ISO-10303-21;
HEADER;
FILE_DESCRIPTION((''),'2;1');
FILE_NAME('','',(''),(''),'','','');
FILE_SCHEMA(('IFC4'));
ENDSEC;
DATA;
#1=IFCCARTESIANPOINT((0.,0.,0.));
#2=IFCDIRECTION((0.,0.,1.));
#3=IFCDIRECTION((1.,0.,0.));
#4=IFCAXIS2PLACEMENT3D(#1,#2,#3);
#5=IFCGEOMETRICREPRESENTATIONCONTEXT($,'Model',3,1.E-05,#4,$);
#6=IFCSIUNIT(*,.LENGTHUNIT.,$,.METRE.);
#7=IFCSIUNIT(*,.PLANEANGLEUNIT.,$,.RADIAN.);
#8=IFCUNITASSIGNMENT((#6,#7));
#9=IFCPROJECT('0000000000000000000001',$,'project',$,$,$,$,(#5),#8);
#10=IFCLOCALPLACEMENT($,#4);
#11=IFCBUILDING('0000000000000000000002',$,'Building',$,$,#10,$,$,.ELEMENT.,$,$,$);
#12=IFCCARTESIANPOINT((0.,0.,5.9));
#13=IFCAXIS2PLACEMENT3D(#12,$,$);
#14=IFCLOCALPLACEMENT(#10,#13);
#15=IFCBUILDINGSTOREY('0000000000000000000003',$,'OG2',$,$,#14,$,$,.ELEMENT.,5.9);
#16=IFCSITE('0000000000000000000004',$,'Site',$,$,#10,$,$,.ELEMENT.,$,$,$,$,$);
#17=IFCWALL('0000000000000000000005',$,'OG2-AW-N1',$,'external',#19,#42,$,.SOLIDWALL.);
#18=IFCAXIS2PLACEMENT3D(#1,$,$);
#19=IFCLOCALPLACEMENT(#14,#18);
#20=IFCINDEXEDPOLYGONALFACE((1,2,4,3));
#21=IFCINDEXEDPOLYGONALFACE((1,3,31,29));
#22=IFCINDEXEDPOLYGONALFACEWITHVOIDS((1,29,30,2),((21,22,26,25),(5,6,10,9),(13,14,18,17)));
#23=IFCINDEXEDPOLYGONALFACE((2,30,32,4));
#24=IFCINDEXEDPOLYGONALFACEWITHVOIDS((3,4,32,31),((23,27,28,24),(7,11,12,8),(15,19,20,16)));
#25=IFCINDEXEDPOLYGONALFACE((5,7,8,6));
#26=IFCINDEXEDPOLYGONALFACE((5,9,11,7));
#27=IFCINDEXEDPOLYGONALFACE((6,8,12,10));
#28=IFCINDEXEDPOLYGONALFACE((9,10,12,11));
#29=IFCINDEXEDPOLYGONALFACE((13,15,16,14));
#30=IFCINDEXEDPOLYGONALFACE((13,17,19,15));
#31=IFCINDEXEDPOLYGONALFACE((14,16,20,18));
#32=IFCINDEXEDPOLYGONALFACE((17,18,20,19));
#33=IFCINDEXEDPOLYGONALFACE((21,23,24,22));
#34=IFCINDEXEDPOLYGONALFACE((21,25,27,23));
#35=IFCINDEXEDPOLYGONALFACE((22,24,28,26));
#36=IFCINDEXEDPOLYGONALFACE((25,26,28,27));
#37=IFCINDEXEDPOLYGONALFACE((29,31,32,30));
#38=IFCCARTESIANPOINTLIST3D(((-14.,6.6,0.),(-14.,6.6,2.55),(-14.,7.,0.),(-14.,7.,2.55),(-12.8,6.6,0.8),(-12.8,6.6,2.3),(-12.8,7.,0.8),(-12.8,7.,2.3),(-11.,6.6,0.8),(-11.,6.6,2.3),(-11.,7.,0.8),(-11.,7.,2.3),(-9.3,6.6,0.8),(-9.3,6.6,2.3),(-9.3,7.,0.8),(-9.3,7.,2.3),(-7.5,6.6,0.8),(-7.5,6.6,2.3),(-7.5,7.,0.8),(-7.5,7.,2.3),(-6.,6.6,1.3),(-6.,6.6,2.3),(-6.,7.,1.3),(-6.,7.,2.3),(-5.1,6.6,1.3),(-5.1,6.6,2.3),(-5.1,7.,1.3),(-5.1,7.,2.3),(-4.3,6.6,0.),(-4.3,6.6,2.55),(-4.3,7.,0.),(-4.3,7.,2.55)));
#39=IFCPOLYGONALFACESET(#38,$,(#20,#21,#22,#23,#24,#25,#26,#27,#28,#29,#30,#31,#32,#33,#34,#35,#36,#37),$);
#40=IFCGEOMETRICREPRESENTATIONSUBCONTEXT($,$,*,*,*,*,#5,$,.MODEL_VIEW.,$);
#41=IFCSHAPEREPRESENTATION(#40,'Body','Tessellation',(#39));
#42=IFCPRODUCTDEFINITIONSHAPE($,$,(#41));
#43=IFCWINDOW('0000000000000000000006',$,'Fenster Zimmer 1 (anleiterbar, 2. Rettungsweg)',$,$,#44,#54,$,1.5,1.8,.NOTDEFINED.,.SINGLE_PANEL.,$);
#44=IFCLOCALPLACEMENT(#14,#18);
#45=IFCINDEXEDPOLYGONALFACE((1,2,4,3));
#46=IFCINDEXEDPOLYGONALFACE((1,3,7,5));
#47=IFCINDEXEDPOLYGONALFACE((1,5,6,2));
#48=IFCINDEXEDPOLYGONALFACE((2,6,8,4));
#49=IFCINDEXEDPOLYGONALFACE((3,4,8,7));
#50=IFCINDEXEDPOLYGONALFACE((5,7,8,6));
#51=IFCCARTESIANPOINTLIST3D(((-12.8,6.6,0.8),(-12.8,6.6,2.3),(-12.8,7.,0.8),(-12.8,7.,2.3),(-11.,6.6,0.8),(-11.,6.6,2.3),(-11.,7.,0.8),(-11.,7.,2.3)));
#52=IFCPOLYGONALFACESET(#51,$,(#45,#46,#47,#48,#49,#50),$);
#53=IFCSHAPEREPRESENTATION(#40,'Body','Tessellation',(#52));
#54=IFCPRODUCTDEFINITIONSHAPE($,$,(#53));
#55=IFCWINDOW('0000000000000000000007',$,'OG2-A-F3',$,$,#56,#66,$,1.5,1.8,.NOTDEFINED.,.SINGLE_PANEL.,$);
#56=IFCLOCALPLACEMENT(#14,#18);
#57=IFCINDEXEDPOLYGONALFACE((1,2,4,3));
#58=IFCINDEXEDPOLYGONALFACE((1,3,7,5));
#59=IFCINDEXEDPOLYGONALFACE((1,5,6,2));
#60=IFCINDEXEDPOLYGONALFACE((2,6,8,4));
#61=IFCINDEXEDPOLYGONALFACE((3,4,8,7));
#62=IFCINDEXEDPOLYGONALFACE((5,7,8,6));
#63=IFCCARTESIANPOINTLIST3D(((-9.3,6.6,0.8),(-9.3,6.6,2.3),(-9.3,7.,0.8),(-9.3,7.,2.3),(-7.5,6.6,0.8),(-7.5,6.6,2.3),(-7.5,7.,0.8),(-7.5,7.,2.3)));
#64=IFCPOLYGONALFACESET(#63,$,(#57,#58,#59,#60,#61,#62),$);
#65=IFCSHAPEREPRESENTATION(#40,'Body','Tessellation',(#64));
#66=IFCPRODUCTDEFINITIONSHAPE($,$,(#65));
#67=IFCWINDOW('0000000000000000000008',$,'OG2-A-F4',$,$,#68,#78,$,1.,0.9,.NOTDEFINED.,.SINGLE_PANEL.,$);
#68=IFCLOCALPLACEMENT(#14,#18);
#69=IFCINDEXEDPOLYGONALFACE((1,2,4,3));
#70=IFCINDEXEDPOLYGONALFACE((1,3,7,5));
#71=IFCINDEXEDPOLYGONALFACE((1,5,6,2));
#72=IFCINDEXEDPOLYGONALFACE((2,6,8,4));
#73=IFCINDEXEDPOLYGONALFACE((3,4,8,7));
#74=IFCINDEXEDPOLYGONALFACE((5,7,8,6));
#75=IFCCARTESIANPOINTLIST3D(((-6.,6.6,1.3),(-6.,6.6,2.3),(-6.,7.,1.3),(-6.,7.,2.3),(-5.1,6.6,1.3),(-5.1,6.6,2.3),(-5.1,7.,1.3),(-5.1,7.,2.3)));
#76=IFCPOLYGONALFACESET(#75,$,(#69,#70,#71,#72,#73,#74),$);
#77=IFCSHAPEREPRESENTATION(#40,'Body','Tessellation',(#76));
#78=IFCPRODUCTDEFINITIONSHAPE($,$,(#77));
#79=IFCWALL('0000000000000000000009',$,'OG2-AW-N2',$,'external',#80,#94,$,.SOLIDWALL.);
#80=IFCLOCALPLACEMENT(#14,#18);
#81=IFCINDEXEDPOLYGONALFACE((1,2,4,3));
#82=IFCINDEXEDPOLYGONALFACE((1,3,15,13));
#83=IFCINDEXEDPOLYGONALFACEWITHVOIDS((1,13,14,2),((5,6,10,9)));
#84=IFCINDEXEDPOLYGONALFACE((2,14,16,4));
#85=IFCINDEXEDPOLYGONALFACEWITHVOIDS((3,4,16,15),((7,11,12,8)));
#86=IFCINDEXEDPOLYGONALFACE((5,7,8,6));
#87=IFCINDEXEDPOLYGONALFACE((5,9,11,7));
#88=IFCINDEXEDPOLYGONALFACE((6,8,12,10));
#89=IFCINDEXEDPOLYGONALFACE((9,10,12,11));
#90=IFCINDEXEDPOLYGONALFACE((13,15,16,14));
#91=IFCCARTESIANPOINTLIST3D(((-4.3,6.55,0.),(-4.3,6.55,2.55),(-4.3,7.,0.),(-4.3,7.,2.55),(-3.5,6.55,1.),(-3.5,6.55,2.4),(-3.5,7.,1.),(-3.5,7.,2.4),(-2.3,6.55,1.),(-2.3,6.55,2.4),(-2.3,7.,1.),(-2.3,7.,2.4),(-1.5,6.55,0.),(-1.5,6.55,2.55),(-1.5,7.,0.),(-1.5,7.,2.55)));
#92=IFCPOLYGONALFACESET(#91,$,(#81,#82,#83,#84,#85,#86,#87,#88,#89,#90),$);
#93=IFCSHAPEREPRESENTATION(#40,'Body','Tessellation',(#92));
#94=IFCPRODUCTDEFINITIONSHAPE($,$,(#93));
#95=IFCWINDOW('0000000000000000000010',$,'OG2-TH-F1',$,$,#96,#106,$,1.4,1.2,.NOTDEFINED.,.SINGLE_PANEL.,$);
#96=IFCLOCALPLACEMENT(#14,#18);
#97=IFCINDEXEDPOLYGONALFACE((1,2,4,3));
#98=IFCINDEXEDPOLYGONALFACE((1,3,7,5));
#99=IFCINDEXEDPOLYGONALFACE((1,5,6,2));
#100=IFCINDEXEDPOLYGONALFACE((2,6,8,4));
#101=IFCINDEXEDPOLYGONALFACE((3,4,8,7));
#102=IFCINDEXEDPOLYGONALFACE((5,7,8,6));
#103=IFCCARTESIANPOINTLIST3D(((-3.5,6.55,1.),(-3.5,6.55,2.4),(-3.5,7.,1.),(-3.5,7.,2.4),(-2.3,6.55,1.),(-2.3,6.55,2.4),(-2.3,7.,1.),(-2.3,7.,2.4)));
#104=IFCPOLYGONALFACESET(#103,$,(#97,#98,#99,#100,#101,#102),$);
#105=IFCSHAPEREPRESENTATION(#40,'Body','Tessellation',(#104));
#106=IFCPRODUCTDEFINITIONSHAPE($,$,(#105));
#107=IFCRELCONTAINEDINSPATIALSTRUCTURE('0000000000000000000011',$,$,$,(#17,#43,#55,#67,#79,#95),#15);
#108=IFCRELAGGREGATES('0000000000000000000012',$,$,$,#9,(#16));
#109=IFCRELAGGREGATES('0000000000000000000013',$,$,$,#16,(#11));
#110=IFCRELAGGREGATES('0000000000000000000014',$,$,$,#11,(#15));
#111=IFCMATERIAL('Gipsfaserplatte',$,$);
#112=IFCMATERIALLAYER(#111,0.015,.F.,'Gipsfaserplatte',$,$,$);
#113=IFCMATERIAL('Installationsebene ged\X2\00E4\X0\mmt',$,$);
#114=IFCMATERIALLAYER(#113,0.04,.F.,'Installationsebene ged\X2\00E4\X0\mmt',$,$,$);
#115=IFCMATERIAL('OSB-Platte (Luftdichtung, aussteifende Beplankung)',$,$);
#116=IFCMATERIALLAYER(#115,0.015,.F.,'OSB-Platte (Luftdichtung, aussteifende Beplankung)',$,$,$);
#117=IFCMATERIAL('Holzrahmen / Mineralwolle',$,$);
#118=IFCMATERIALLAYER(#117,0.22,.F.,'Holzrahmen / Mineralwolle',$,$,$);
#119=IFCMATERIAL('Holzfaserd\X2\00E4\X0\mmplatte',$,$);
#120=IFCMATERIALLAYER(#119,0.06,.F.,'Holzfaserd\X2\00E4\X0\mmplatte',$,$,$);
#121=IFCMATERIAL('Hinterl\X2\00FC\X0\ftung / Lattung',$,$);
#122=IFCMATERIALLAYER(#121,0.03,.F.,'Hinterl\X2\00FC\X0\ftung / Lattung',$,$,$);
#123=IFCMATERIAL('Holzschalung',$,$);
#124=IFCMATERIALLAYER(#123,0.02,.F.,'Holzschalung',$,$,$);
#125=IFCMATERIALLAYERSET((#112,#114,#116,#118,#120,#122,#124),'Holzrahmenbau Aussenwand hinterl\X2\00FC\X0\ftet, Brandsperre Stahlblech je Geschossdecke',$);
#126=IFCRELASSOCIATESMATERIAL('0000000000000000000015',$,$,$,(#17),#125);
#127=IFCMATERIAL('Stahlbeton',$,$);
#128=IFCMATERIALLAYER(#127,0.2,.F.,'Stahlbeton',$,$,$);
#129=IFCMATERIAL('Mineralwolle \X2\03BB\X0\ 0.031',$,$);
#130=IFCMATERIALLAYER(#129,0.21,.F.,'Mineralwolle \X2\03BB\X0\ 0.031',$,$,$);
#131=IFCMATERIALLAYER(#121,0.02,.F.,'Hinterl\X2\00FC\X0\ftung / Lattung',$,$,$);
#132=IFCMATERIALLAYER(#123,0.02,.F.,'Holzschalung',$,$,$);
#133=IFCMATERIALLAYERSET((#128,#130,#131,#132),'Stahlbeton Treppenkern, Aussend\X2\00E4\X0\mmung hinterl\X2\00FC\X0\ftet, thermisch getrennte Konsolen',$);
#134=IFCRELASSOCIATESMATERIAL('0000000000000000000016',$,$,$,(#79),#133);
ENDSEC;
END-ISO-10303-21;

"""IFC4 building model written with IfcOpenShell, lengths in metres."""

from ifc_helpers import new_model, si_unit, frame, frame_2d, origin, origin_with_axes, place, context, subcontext, project, spatial, rectangle, extrude, material, layer, layer_set, element, fill, save


model = new_model("IFC4")

# Units and contexts
model_context = context("Model", 3, precision=1e-05, world=origin_with_axes())
sub_context = subcontext(model_context, None, None, "MODEL_VIEW")
ifc_project = project(units=[si_unit("LENGTHUNIT", "METRE"), si_unit("PLANEANGLEUNIT", "RADIAN")], contexts=[model_context])

# Site, building, storey
placement = place(None, origin_with_axes())
site = spatial("IfcSite", under=ifc_project, at=placement, Name="Site", CompositionType="ELEMENT")
building = spatial("IfcBuilding", under=site, at=placement, Name="Building", CompositionType="ELEMENT")
storey_placement = place(placement, frame((0.0, 0.0, 5.9)))
storey = spatial("IfcBuildingStorey", under=building, at=storey_placement, Name="OG2", CompositionType="ELEMENT", Elevation=5.9)

# Wall, openings, windows
ifc_material_1 = material(Name="Gipsfaserplatte")
ifc_layer_1 = layer(ifc_material_1, 0.015, ventilated=False, Name="Gipsfaserplatte")
ifc_material_2 = material(Name="Installationsebene gedämmt")
ifc_layer_2 = layer(ifc_material_2, 0.04, ventilated=False, Name="Installationsebene gedämmt")
ifc_material_3 = material(Name="OSB-Platte (Luftdichtung, aussteifende Beplankung)")
ifc_layer_3 = layer(ifc_material_3, 0.015, ventilated=False, Name="OSB-Platte (Luftdichtung, aussteifende Beplankung)")
ifc_material_4 = material(Name="Holzrahmen / Mineralwolle")
ifc_layer_4 = layer(ifc_material_4, 0.22, ventilated=False, Name="Holzrahmen / Mineralwolle")
ifc_material_5 = material(Name="Holzfaserdämmplatte")
ifc_layer_5 = layer(ifc_material_5, 0.06, ventilated=False, Name="Holzfaserdämmplatte")
ifc_material_6 = material(Name="Hinterlüftung / Lattung")
ifc_layer_6 = layer(ifc_material_6, 0.03, ventilated=False, Name="Hinterlüftung / Lattung")
ifc_material_7 = material(Name="Holzschalung")
ifc_layer_7 = layer(ifc_material_7, 0.02, ventilated=False, Name="Holzschalung")
ifc_layer_set_1 = layer_set([ifc_layer_1, ifc_layer_2, ifc_layer_3, ifc_layer_4, ifc_layer_5, ifc_layer_6, ifc_layer_7], Name="Holzrahmenbau Aussenwand hinterlüftet, Brandsperre Stahlblech je Geschossdecke")
wall_1_placement = place(storey_placement, frame((-14.0, 6.8, 0.0), z_axis=(0.0, 0.0, 1.0), x_axis=(1.0, 0.0, 0.0)))
wall_1 = element("IfcWall", 1, at=wall_1_placement, inside=storey, material=ifc_layer_set_1, Name="OG2-AW-N1", ObjectType="external", PredefinedType="SOLIDWALL", context=sub_context, shape_type="SweptSolid", body=[
    extrude(rectangle(XDim=9.7, YDim=0.4, at=frame_2d((4.85, 0.0))), origin(), (0.0, 0.0, 1.0), 2.55),
])
opening_1_placement = place(wall_1_placement, frame((2.1, 0.25, 0.8), z_axis=(0.0, -1.0, 0.0), x_axis=(1.0, 0.0, 0.0)))
opening_1 = element("IfcOpeningElement", 2, at=opening_1_placement, cuts=wall_1, PredefinedType="OPENING", context=sub_context, shape_type="SweptSolid", body=[
    extrude(rectangle(XDim=1.8, YDim=1.5, at=frame_2d((0.0, 0.75))), origin(), (0.0, 0.0, 1.0), 0.5),
])
opening_2_placement = place(wall_1_placement, frame((5.6, 0.25, 0.8), z_axis=(0.0, -1.0, 0.0), x_axis=(1.0, 0.0, 0.0)))
opening_2 = element("IfcOpeningElement", 3, at=opening_2_placement, cuts=wall_1, PredefinedType="OPENING", context=sub_context, shape_type="SweptSolid", body=[
    extrude(rectangle(XDim=1.8, YDim=1.5, at=frame_2d((0.0, 0.75))), origin(), (0.0, 0.0, 1.0), 0.5),
])
opening_3_placement = place(wall_1_placement, frame((8.45, 0.25, 1.3), z_axis=(0.0, -1.0, 0.0), x_axis=(1.0, 0.0, 0.0)))
opening_3 = element("IfcOpeningElement", 4, at=opening_3_placement, cuts=wall_1, PredefinedType="OPENING", context=sub_context, shape_type="SweptSolid", body=[
    extrude(rectangle(XDim=0.9, YDim=1.0, at=frame_2d((0.0, 0.5))), origin(), (0.0, 0.0, 1.0), 0.5),
])
window_1_placement = place(wall_1_placement, frame((2.1, 0.2, 0.8), z_axis=(0.0, -1.0, 0.0), x_axis=(1.0, 0.0, 0.0)))
window_1 = element("IfcWindow", 5, at=window_1_placement, inside=storey, Name="Fenster Zimmer 1 (anleiterbar, 2. Rettungsweg)", OverallHeight=1.5, OverallWidth=1.8, PartitioningType="SINGLE_PANEL", PredefinedType="NOTDEFINED", context=sub_context, shape_type="SweptSolid", body=[
    extrude(rectangle(XDim=1.8, YDim=1.5, at=frame_2d((0.0, 0.75))), origin(), (0.0, 0.0, 1.0), 0.4),
])
fill(opening_1, window_1)
window_2_placement = place(wall_1_placement, frame((5.6, 0.2, 0.8), z_axis=(0.0, -1.0, 0.0), x_axis=(1.0, 0.0, 0.0)))
window_2 = element("IfcWindow", 6, at=window_2_placement, inside=storey, Name="OG2-A-F3", OverallHeight=1.5, OverallWidth=1.8, PartitioningType="SINGLE_PANEL", PredefinedType="NOTDEFINED", context=sub_context, shape_type="SweptSolid", body=[
    extrude(rectangle(XDim=1.8, YDim=1.5, at=frame_2d((0.0, 0.75))), origin(), (0.0, 0.0, 1.0), 0.4),
])
fill(opening_2, window_2)
window_3_placement = place(wall_1_placement, frame((8.45, 0.2, 1.3), z_axis=(0.0, -1.0, 0.0), x_axis=(1.0, 0.0, 0.0)))
window_3 = element("IfcWindow", 7, at=window_3_placement, inside=storey, Name="OG2-A-F4", OverallHeight=1.0, OverallWidth=0.9, PartitioningType="SINGLE_PANEL", PredefinedType="NOTDEFINED", context=sub_context, shape_type="SweptSolid", body=[
    extrude(rectangle(XDim=0.9, YDim=1.0, at=frame_2d((0.0, 0.5))), origin(), (0.0, 0.0, 1.0), 0.4),
])
fill(opening_3, window_3)

# Wall, opening, window
ifc_material_8 = material(Name="Stahlbeton")
ifc_layer_8 = layer(ifc_material_8, 0.2, ventilated=False, Name="Stahlbeton")
ifc_material_9 = material(Name="Mineralwolle λ 0.031")
ifc_layer_9 = layer(ifc_material_9, 0.21, ventilated=False, Name="Mineralwolle λ 0.031")
ifc_layer_10 = layer(ifc_material_6, 0.02, ventilated=False, Name="Hinterlüftung / Lattung")
ifc_layer_11 = layer(ifc_material_7, 0.02, ventilated=False, Name="Holzschalung")
ifc_layer_set_2 = layer_set([ifc_layer_8, ifc_layer_9, ifc_layer_10, ifc_layer_11], Name="Stahlbeton Treppenkern, Aussendämmung hinterlüftet, thermisch getrennte Konsolen")
wall_2_placement = place(storey_placement, frame((-4.3, 6.775, 0.0), z_axis=(0.0, 0.0, 1.0), x_axis=(1.0, 0.0, 0.0)))
wall_2 = element("IfcWall", 8, at=wall_2_placement, inside=storey, material=ifc_layer_set_2, Name="OG2-AW-N2", ObjectType="external", PredefinedType="SOLIDWALL", context=sub_context, shape_type="SweptSolid", body=[
    extrude(rectangle(XDim=2.8, YDim=0.45, at=frame_2d((1.4, 0.0))), origin(), (0.0, 0.0, 1.0), 2.55),
])
opening_4_placement = place(wall_2_placement, frame((1.4, 0.275, 1.0), z_axis=(0.0, -1.0, 0.0), x_axis=(1.0, 0.0, 0.0)))
opening_4 = element("IfcOpeningElement", 9, at=opening_4_placement, cuts=wall_2, PredefinedType="OPENING", context=sub_context, shape_type="SweptSolid", body=[
    extrude(rectangle(XDim=1.2, YDim=1.4, at=frame_2d((0.0, 0.7))), origin(), (0.0, 0.0, 1.0), 0.55),
])
window_4_placement = place(wall_2_placement, frame((1.4, 0.225, 1.0), z_axis=(0.0, -1.0, 0.0), x_axis=(1.0, 0.0, 0.0)))
window_4 = element("IfcWindow", 10, at=window_4_placement, inside=storey, Name="OG2-TH-F1", OverallHeight=1.4, OverallWidth=1.2, PartitioningType="SINGLE_PANEL", PredefinedType="NOTDEFINED", context=sub_context, shape_type="SweptSolid", body=[
    extrude(rectangle(XDim=1.2, YDim=1.4, at=frame_2d((0.0, 0.7))), origin(), (0.0, 0.0, 1.0), 0.45),
])
fill(opening_4, window_4)

save(model, "model.ifc")
